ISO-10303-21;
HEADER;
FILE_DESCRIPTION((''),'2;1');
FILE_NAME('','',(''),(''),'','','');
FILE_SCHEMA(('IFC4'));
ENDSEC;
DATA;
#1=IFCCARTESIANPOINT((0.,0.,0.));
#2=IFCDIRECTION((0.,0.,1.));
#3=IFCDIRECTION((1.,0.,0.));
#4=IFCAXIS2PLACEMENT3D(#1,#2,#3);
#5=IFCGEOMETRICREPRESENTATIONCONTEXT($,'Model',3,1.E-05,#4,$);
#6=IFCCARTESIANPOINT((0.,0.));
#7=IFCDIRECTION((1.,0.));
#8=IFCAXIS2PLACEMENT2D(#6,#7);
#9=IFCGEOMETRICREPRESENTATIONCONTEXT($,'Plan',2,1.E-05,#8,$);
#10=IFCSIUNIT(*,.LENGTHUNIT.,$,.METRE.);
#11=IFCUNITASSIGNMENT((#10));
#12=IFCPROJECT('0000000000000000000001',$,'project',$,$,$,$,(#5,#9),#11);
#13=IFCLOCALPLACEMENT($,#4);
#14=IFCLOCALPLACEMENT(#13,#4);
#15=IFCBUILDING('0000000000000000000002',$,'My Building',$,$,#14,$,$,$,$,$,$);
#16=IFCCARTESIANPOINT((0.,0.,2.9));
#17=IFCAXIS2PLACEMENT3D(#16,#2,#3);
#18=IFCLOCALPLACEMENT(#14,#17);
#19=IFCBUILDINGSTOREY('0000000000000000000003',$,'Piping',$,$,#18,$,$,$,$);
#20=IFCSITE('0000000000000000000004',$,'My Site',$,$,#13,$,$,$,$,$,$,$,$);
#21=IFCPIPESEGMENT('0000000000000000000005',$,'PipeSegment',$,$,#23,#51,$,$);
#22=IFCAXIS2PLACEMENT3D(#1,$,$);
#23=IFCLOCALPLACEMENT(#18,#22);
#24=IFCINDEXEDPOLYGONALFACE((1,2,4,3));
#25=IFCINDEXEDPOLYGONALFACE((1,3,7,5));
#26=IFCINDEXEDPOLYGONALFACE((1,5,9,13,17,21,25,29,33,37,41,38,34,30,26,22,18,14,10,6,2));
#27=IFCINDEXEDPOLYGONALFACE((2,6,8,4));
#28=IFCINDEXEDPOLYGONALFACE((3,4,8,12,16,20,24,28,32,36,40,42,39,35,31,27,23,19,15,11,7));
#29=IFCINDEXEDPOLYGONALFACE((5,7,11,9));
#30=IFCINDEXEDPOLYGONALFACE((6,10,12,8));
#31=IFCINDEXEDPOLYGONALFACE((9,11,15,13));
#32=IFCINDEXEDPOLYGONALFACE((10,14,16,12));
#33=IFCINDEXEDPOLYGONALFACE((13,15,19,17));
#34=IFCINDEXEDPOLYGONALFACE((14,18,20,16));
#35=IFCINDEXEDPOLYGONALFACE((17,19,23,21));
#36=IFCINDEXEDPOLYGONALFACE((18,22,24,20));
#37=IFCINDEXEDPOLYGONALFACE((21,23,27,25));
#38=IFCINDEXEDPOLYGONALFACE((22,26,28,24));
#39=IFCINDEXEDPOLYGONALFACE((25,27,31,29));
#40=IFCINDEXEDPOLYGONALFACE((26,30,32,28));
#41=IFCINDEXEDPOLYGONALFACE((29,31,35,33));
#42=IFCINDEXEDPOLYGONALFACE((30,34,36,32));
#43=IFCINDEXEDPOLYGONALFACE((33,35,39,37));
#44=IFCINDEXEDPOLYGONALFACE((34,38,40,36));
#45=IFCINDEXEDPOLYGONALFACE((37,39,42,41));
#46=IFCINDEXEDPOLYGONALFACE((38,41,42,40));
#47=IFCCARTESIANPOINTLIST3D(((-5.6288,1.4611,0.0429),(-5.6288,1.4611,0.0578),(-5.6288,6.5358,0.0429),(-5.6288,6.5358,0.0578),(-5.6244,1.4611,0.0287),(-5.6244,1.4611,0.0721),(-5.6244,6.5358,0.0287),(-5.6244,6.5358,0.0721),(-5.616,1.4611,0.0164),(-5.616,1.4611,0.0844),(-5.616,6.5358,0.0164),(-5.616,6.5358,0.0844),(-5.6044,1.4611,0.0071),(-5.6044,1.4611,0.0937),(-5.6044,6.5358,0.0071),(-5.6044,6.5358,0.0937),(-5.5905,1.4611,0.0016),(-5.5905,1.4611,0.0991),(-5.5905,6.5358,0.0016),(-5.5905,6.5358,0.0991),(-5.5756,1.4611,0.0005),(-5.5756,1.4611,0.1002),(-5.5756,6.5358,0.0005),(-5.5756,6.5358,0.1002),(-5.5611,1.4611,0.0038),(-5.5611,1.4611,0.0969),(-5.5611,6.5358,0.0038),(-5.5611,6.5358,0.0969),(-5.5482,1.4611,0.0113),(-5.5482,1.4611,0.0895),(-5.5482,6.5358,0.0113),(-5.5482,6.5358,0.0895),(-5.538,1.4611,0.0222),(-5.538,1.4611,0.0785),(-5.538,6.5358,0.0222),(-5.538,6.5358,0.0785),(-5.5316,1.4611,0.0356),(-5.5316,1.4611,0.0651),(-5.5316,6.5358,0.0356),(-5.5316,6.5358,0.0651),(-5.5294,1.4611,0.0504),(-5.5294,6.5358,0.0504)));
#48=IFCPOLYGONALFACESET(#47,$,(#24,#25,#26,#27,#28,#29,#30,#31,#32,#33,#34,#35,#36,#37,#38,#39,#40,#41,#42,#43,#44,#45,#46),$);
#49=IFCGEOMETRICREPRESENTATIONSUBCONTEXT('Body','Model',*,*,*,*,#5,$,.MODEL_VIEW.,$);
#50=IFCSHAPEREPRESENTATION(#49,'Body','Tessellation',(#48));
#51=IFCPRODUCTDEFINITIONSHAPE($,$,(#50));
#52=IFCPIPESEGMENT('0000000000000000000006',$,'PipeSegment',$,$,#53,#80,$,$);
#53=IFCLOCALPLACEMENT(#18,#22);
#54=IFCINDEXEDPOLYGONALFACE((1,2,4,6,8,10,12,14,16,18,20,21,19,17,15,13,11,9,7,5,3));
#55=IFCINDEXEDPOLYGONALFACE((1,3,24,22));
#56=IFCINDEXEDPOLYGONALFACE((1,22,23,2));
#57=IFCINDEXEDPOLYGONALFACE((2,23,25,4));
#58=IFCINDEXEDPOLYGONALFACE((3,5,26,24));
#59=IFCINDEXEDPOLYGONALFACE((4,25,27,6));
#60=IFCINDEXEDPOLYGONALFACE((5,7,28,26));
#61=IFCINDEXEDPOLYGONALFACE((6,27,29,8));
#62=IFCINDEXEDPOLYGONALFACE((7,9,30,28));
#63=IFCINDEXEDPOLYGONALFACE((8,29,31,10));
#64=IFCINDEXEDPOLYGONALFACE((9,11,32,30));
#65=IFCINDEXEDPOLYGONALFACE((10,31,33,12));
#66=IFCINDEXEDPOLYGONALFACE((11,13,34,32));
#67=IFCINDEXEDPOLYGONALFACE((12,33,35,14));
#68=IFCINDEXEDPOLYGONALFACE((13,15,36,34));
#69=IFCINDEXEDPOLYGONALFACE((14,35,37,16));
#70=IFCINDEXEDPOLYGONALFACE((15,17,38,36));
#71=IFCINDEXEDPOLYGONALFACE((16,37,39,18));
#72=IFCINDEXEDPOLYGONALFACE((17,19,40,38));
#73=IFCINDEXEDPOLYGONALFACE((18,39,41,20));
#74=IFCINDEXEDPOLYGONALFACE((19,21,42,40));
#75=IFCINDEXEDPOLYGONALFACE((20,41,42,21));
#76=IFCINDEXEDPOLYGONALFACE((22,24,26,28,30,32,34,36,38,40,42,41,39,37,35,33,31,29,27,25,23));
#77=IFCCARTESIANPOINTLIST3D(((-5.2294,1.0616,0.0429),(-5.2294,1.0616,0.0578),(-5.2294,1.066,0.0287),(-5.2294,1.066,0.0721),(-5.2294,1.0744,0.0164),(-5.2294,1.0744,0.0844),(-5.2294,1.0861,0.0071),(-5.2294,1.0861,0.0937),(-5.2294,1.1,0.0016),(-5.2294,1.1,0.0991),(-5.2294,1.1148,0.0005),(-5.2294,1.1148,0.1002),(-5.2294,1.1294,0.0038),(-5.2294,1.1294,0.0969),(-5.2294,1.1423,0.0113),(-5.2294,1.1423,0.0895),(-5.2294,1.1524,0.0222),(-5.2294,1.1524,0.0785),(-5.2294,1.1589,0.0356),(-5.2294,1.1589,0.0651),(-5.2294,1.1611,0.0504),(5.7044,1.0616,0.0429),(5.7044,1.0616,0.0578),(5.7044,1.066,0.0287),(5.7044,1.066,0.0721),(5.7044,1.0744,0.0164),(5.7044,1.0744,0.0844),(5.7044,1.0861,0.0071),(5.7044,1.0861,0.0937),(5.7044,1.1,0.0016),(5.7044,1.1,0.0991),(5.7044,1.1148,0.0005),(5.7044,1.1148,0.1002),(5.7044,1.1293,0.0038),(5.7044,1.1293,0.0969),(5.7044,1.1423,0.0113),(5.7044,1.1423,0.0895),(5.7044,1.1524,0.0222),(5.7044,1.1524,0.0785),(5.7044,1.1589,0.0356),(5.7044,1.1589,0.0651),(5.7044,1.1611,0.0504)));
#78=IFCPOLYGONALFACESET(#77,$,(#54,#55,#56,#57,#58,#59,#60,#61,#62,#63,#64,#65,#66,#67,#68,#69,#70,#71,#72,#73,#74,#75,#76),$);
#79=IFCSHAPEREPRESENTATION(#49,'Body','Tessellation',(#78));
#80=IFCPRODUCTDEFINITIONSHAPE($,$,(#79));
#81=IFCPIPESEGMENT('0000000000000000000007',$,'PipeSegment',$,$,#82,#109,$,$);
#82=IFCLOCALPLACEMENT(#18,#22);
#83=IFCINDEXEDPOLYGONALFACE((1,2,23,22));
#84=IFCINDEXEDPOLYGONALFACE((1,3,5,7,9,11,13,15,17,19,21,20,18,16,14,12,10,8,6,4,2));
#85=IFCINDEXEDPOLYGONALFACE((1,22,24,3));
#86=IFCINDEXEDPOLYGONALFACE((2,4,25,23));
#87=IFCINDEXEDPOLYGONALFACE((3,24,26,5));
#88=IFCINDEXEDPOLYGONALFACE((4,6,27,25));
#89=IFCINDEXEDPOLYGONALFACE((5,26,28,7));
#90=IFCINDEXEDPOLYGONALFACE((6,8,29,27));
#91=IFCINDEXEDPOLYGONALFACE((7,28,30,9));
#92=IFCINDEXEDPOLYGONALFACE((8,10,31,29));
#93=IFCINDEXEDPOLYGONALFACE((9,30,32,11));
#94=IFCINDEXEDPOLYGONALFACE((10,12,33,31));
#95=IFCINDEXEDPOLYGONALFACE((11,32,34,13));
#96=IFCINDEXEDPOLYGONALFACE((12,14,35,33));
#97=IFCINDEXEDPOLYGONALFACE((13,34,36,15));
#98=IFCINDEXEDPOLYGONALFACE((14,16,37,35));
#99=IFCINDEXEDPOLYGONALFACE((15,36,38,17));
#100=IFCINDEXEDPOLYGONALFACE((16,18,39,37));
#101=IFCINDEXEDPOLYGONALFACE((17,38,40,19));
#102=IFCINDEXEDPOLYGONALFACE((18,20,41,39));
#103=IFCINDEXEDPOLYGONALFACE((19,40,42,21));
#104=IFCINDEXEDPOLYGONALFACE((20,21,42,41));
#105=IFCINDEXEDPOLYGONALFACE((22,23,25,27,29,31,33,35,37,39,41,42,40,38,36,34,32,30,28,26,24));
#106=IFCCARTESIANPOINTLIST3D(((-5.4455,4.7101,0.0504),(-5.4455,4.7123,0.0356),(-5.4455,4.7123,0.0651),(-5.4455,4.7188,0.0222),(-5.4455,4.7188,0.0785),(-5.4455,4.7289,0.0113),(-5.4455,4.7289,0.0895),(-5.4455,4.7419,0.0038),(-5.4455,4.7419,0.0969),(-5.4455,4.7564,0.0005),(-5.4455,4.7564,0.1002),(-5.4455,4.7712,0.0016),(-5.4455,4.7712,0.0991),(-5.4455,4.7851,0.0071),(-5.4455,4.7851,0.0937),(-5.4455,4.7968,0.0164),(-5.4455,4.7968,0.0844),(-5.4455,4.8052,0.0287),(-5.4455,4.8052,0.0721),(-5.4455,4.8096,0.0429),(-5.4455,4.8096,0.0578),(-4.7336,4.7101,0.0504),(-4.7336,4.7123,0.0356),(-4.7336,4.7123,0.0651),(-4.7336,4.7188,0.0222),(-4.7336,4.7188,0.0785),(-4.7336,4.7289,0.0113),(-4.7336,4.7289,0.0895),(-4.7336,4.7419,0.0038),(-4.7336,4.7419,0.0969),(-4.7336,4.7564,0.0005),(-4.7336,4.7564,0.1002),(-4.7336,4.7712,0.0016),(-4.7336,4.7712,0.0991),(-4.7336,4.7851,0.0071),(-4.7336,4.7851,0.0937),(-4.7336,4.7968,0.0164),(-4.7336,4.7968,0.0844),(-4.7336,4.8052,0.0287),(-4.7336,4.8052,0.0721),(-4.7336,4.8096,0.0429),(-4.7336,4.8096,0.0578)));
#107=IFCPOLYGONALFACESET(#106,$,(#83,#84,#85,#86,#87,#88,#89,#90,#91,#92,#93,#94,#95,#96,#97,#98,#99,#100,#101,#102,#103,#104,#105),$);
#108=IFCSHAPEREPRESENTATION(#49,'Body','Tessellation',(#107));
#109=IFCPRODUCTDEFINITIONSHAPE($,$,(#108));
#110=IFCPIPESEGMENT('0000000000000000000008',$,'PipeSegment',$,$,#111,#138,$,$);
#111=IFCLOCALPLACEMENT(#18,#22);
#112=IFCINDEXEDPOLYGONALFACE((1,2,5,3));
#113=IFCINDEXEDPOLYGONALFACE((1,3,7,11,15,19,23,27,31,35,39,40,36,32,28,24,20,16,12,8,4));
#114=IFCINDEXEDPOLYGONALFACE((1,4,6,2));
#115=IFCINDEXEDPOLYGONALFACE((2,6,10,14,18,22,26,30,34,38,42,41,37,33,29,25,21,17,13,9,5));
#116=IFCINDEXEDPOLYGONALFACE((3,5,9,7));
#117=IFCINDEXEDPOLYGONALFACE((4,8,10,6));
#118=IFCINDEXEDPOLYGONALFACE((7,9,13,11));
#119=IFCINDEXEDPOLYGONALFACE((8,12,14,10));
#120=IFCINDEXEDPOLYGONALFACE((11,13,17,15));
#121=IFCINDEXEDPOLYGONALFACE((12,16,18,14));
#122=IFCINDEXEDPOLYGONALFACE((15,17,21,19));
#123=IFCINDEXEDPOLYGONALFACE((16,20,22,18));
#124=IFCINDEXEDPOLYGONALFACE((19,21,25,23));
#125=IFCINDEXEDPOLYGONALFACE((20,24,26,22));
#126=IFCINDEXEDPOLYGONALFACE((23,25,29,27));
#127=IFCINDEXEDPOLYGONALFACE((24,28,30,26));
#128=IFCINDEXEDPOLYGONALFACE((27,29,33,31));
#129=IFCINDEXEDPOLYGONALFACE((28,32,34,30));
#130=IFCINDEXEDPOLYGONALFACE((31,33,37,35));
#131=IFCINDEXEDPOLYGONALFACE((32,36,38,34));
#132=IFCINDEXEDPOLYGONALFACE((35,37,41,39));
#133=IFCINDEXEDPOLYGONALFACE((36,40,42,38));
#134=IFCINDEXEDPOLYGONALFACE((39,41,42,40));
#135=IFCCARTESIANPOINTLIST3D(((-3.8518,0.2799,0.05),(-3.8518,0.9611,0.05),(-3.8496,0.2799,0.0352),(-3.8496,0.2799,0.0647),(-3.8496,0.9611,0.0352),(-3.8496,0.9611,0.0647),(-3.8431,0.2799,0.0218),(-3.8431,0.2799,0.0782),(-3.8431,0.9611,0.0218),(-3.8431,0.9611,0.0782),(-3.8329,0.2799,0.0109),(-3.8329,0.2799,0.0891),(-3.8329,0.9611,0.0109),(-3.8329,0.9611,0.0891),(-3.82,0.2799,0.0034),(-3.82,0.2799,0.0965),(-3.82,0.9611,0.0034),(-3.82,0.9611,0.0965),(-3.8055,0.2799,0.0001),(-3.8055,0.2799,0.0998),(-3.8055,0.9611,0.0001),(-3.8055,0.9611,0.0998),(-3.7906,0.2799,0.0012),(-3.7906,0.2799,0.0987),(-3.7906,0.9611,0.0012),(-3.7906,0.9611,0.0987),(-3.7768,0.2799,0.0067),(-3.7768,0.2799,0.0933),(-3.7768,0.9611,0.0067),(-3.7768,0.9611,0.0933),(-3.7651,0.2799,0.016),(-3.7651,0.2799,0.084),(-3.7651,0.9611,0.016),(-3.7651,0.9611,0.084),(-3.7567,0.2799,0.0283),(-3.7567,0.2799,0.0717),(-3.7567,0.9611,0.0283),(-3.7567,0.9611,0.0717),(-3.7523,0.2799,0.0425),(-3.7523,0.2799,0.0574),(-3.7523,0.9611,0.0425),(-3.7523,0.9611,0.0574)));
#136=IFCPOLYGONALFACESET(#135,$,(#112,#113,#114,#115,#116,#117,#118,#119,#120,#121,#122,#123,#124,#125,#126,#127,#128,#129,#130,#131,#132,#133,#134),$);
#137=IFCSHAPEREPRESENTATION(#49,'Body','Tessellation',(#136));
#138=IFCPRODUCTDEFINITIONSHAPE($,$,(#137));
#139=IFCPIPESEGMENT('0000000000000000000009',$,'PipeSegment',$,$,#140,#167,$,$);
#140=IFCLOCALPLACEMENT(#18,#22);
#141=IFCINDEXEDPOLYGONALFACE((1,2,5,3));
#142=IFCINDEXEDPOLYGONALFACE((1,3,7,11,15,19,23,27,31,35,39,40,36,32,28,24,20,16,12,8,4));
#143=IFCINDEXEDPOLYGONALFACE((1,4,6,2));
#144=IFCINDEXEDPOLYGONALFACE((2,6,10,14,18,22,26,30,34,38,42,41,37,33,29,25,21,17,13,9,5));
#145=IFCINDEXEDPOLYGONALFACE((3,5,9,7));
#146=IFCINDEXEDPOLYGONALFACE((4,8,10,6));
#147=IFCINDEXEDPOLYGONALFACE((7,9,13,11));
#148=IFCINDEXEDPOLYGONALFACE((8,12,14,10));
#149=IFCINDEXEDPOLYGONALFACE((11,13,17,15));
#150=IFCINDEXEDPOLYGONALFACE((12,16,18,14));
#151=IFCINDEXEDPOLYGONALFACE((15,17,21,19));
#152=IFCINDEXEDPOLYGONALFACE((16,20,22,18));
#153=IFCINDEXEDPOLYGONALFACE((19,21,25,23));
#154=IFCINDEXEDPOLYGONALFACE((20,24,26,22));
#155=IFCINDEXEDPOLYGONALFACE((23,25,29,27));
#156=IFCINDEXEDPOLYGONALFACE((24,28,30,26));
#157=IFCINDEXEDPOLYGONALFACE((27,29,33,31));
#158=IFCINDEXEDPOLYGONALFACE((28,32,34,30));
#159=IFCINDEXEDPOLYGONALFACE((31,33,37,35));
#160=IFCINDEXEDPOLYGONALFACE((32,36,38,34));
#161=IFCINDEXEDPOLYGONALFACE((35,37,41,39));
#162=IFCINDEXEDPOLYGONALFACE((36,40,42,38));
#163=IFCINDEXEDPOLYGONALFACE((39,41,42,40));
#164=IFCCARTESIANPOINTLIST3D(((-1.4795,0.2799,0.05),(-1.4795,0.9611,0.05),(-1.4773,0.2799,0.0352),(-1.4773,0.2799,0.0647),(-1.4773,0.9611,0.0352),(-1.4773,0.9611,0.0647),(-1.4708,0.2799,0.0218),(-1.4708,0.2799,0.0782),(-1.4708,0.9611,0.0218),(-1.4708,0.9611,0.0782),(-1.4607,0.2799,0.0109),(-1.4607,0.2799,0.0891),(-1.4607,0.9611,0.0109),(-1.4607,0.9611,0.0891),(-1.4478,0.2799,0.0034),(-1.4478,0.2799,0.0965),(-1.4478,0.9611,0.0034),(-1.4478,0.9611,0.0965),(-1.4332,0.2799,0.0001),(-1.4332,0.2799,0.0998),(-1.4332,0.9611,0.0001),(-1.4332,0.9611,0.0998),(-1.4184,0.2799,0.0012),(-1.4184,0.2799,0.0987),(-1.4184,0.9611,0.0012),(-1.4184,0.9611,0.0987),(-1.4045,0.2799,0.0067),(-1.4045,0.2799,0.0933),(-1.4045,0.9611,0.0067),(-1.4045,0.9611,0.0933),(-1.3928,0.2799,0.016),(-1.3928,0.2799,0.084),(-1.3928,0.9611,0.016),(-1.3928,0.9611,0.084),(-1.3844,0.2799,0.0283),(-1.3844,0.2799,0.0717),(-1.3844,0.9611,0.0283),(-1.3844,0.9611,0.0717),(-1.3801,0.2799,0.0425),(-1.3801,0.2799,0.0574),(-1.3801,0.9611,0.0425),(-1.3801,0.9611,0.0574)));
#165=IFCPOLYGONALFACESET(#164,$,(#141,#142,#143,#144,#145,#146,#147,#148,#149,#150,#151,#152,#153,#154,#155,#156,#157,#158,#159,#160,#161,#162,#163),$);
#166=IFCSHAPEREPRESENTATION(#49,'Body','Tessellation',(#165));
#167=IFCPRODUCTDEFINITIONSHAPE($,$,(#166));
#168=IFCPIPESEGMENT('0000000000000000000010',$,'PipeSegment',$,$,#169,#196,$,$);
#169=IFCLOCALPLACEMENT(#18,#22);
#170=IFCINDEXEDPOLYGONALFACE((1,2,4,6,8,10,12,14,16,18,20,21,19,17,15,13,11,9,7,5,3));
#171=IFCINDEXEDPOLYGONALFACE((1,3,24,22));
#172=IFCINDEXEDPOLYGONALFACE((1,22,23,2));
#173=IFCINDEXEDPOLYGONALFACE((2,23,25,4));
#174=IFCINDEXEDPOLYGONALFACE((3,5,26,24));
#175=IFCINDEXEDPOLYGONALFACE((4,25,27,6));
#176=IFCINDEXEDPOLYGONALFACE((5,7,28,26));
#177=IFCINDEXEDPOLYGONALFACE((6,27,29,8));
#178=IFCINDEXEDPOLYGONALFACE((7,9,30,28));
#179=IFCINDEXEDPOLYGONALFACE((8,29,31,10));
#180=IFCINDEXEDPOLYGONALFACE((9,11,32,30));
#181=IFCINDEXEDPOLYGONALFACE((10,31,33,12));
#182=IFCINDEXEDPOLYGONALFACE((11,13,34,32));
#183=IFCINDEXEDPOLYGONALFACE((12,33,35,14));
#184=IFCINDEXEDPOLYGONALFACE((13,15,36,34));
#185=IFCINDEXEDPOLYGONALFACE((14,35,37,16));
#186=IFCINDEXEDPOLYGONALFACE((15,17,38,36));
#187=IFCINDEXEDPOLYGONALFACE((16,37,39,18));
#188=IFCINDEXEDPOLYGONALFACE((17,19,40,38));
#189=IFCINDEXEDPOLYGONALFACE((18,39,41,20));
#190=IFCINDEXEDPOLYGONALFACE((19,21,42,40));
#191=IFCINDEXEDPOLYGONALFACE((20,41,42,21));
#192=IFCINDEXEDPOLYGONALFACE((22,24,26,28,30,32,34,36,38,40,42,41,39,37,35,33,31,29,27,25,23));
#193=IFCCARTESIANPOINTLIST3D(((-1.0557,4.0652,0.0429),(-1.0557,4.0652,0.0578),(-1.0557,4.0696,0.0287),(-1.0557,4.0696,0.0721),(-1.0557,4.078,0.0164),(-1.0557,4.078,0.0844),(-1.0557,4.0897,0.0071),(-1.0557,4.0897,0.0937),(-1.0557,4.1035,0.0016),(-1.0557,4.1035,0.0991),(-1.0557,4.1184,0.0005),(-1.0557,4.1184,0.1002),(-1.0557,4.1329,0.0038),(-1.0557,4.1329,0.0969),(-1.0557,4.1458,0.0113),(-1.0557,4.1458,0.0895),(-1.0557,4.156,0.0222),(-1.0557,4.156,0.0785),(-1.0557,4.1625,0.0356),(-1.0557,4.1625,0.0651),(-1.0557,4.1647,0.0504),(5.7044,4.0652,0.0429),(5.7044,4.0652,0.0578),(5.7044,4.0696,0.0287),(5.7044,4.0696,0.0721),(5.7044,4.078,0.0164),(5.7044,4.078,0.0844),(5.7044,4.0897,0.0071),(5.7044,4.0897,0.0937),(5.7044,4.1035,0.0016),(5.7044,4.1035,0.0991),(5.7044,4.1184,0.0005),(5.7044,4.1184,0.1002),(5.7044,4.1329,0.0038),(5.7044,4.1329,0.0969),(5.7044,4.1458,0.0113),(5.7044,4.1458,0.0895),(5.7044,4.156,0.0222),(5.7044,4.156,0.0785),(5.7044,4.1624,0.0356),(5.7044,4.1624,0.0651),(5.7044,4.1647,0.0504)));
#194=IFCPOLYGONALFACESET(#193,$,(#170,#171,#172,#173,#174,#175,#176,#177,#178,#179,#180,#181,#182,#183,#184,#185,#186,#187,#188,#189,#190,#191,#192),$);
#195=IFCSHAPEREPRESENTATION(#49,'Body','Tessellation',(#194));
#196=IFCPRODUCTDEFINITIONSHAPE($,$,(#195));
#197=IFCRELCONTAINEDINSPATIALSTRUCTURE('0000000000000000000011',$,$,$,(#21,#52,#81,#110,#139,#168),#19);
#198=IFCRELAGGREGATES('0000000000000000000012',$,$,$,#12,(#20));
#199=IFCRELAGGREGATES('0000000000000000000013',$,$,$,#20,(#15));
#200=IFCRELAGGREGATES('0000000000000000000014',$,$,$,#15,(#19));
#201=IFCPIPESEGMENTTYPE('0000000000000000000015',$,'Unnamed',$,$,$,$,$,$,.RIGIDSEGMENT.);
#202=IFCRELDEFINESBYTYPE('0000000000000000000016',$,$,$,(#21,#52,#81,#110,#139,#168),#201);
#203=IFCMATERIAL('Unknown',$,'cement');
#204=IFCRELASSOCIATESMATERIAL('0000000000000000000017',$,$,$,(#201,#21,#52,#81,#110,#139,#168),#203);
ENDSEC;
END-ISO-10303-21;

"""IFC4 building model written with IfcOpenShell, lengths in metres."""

from ifc_helpers import new_model, si_unit, frame, origin_with_axes, origin_2d_with_axis, place, context, subcontext, project, spatial, circle, extrude, material, material_profile, profile_set, profile_usage, type_object, element, save


model = new_model("IFC4")

# Units and contexts
model_context = context("Model", 3, precision=1e-05, world=origin_with_axes())
plan_context = context("Plan", 2, precision=1e-05, world=origin_2d_with_axis())
body_context = subcontext(model_context, "Body", "Model", "MODEL_VIEW")
ifc_project = project(units=[si_unit("LENGTHUNIT", "METRE")], contexts=[model_context, plan_context])

# Site, building, storey
site_placement = place(None, origin_with_axes())
site = spatial("IfcSite", under=ifc_project, at=site_placement, Name="My Site")
building_placement = place(site_placement, origin_with_axes())
building = spatial("IfcBuilding", under=site, at=building_placement, Name="My Building")
storey_placement = place(building_placement, frame((0.0, 0.0, 2.9), z_axis=(0.0, 0.0, 1.0), x_axis=(1.0, 0.0, 0.0)))
storey = spatial("IfcBuildingStorey", under=building, at=storey_placement, Name="Piping")

# Pipe segments
ifc_material = material(Name="Unknown", Category="cement")
ifc_material_profile_1 = material_profile(ifc_material, circle(Radius=0.05))
ifc_profile_set_1 = profile_set([ifc_material_profile_1])
ifc_profile_usage_1 = profile_usage(ifc_profile_set_1, cardinal=5)
pipe_segment_type = type_object("IfcPipeSegmentType", Name="Unnamed", PredefinedType="RIGIDSEGMENT", material=ifc_profile_set_1)
pipe_segment_1_placement = place(storey_placement, frame((-5.5794, 6.5358, 0.0504), z_axis=(0.0, -1.0, 0.0), x_axis=(1.0, 0.0, 0.0)))
element("IfcPipeSegment", 1, at=pipe_segment_1_placement, inside=storey, type_object=pipe_segment_type, material=ifc_profile_usage_1, Name="PipeSegment", context=body_context, shape_type="SweptSolid", body=[
    extrude(circle(Radius=0.05), origin_with_axes(), (0.0, 0.0, 1.0), 5.0747),
])
ifc_profile_usage_2 = profile_usage(ifc_profile_set_1, cardinal=5)
pipe_segment_2_placement = place(storey_placement, frame((-5.2294, 1.1111, 0.0504), z_axis=(1.0, -0.000001, 0.000001), x_axis=(0.000001, 1.0, 0.0)))
element("IfcPipeSegment", 2, at=pipe_segment_2_placement, inside=storey, type_object=pipe_segment_type, material=ifc_profile_usage_2, Name="PipeSegment", context=body_context, shape_type="SweptSolid", body=[
    extrude(circle(Radius=0.05), origin_with_axes(), (0.0, 0.0, 1.0), 10.9338),
])
ifc_profile_usage_3 = profile_usage(ifc_profile_set_1, cardinal=5)
pipe_segment_3_placement = place(storey_placement, frame((-4.7336, 4.7601, 0.0504), z_axis=(-1.0, 0.0, 0.0), x_axis=(0.0, -1.0, 0.0)))
element("IfcPipeSegment", 3, at=pipe_segment_3_placement, inside=storey, type_object=pipe_segment_type, material=ifc_profile_usage_3, Name="PipeSegment", context=body_context, shape_type="SweptSolid", body=[
    extrude(circle(Radius=0.05), origin_with_axes(), (0.0, 0.0, 1.0), 0.7119),
])
ifc_profile_usage_4 = profile_usage(ifc_profile_set_1, cardinal=5)
pipe_segment_4_placement = place(storey_placement, frame((-3.8018, 0.2799, 0.05), z_axis=(0.0, 1.0, 0.0), x_axis=(-1.0, 0.0, 0.0)))
element("IfcPipeSegment", 4, at=pipe_segment_4_placement, inside=storey, type_object=pipe_segment_type, material=ifc_profile_usage_4, Name="PipeSegment", context=body_context, shape_type="SweptSolid", body=[
    extrude(circle(Radius=0.05), origin_with_axes(), (0.0, 0.0, 1.0), 0.6812),
])
ifc_profile_usage_5 = profile_usage(ifc_profile_set_1, cardinal=5)
pipe_segment_5_placement = place(storey_placement, frame((-1.4295, 0.2799, 0.05), z_axis=(0.0, 1.0, 0.0), x_axis=(-1.0, 0.0, 0.0)))
element("IfcPipeSegment", 5, at=pipe_segment_5_placement, inside=storey, type_object=pipe_segment_type, material=ifc_profile_usage_5, Name="PipeSegment", context=body_context, shape_type="SweptSolid", body=[
    extrude(circle(Radius=0.05), origin_with_axes(), (0.0, 0.0, 1.0), 0.6812),
])
ifc_profile_usage_6 = profile_usage(ifc_profile_set_1, cardinal=5)
pipe_segment_6_placement = place(storey_placement, frame((-1.0557, 4.1147, 0.0504), z_axis=(1.0, -0.000001, 0.000001), x_axis=(0.000001, 1.0, 0.0)))
element("IfcPipeSegment", 6, at=pipe_segment_6_placement, inside=storey, type_object=pipe_segment_type, material=ifc_profile_usage_6, Name="PipeSegment", context=body_context, shape_type="SweptSolid", body=[
    extrude(circle(Radius=0.05), origin_with_axes(), (0.0, 0.0, 1.0), 6.7601),
])

save(model, "model.ifc")
